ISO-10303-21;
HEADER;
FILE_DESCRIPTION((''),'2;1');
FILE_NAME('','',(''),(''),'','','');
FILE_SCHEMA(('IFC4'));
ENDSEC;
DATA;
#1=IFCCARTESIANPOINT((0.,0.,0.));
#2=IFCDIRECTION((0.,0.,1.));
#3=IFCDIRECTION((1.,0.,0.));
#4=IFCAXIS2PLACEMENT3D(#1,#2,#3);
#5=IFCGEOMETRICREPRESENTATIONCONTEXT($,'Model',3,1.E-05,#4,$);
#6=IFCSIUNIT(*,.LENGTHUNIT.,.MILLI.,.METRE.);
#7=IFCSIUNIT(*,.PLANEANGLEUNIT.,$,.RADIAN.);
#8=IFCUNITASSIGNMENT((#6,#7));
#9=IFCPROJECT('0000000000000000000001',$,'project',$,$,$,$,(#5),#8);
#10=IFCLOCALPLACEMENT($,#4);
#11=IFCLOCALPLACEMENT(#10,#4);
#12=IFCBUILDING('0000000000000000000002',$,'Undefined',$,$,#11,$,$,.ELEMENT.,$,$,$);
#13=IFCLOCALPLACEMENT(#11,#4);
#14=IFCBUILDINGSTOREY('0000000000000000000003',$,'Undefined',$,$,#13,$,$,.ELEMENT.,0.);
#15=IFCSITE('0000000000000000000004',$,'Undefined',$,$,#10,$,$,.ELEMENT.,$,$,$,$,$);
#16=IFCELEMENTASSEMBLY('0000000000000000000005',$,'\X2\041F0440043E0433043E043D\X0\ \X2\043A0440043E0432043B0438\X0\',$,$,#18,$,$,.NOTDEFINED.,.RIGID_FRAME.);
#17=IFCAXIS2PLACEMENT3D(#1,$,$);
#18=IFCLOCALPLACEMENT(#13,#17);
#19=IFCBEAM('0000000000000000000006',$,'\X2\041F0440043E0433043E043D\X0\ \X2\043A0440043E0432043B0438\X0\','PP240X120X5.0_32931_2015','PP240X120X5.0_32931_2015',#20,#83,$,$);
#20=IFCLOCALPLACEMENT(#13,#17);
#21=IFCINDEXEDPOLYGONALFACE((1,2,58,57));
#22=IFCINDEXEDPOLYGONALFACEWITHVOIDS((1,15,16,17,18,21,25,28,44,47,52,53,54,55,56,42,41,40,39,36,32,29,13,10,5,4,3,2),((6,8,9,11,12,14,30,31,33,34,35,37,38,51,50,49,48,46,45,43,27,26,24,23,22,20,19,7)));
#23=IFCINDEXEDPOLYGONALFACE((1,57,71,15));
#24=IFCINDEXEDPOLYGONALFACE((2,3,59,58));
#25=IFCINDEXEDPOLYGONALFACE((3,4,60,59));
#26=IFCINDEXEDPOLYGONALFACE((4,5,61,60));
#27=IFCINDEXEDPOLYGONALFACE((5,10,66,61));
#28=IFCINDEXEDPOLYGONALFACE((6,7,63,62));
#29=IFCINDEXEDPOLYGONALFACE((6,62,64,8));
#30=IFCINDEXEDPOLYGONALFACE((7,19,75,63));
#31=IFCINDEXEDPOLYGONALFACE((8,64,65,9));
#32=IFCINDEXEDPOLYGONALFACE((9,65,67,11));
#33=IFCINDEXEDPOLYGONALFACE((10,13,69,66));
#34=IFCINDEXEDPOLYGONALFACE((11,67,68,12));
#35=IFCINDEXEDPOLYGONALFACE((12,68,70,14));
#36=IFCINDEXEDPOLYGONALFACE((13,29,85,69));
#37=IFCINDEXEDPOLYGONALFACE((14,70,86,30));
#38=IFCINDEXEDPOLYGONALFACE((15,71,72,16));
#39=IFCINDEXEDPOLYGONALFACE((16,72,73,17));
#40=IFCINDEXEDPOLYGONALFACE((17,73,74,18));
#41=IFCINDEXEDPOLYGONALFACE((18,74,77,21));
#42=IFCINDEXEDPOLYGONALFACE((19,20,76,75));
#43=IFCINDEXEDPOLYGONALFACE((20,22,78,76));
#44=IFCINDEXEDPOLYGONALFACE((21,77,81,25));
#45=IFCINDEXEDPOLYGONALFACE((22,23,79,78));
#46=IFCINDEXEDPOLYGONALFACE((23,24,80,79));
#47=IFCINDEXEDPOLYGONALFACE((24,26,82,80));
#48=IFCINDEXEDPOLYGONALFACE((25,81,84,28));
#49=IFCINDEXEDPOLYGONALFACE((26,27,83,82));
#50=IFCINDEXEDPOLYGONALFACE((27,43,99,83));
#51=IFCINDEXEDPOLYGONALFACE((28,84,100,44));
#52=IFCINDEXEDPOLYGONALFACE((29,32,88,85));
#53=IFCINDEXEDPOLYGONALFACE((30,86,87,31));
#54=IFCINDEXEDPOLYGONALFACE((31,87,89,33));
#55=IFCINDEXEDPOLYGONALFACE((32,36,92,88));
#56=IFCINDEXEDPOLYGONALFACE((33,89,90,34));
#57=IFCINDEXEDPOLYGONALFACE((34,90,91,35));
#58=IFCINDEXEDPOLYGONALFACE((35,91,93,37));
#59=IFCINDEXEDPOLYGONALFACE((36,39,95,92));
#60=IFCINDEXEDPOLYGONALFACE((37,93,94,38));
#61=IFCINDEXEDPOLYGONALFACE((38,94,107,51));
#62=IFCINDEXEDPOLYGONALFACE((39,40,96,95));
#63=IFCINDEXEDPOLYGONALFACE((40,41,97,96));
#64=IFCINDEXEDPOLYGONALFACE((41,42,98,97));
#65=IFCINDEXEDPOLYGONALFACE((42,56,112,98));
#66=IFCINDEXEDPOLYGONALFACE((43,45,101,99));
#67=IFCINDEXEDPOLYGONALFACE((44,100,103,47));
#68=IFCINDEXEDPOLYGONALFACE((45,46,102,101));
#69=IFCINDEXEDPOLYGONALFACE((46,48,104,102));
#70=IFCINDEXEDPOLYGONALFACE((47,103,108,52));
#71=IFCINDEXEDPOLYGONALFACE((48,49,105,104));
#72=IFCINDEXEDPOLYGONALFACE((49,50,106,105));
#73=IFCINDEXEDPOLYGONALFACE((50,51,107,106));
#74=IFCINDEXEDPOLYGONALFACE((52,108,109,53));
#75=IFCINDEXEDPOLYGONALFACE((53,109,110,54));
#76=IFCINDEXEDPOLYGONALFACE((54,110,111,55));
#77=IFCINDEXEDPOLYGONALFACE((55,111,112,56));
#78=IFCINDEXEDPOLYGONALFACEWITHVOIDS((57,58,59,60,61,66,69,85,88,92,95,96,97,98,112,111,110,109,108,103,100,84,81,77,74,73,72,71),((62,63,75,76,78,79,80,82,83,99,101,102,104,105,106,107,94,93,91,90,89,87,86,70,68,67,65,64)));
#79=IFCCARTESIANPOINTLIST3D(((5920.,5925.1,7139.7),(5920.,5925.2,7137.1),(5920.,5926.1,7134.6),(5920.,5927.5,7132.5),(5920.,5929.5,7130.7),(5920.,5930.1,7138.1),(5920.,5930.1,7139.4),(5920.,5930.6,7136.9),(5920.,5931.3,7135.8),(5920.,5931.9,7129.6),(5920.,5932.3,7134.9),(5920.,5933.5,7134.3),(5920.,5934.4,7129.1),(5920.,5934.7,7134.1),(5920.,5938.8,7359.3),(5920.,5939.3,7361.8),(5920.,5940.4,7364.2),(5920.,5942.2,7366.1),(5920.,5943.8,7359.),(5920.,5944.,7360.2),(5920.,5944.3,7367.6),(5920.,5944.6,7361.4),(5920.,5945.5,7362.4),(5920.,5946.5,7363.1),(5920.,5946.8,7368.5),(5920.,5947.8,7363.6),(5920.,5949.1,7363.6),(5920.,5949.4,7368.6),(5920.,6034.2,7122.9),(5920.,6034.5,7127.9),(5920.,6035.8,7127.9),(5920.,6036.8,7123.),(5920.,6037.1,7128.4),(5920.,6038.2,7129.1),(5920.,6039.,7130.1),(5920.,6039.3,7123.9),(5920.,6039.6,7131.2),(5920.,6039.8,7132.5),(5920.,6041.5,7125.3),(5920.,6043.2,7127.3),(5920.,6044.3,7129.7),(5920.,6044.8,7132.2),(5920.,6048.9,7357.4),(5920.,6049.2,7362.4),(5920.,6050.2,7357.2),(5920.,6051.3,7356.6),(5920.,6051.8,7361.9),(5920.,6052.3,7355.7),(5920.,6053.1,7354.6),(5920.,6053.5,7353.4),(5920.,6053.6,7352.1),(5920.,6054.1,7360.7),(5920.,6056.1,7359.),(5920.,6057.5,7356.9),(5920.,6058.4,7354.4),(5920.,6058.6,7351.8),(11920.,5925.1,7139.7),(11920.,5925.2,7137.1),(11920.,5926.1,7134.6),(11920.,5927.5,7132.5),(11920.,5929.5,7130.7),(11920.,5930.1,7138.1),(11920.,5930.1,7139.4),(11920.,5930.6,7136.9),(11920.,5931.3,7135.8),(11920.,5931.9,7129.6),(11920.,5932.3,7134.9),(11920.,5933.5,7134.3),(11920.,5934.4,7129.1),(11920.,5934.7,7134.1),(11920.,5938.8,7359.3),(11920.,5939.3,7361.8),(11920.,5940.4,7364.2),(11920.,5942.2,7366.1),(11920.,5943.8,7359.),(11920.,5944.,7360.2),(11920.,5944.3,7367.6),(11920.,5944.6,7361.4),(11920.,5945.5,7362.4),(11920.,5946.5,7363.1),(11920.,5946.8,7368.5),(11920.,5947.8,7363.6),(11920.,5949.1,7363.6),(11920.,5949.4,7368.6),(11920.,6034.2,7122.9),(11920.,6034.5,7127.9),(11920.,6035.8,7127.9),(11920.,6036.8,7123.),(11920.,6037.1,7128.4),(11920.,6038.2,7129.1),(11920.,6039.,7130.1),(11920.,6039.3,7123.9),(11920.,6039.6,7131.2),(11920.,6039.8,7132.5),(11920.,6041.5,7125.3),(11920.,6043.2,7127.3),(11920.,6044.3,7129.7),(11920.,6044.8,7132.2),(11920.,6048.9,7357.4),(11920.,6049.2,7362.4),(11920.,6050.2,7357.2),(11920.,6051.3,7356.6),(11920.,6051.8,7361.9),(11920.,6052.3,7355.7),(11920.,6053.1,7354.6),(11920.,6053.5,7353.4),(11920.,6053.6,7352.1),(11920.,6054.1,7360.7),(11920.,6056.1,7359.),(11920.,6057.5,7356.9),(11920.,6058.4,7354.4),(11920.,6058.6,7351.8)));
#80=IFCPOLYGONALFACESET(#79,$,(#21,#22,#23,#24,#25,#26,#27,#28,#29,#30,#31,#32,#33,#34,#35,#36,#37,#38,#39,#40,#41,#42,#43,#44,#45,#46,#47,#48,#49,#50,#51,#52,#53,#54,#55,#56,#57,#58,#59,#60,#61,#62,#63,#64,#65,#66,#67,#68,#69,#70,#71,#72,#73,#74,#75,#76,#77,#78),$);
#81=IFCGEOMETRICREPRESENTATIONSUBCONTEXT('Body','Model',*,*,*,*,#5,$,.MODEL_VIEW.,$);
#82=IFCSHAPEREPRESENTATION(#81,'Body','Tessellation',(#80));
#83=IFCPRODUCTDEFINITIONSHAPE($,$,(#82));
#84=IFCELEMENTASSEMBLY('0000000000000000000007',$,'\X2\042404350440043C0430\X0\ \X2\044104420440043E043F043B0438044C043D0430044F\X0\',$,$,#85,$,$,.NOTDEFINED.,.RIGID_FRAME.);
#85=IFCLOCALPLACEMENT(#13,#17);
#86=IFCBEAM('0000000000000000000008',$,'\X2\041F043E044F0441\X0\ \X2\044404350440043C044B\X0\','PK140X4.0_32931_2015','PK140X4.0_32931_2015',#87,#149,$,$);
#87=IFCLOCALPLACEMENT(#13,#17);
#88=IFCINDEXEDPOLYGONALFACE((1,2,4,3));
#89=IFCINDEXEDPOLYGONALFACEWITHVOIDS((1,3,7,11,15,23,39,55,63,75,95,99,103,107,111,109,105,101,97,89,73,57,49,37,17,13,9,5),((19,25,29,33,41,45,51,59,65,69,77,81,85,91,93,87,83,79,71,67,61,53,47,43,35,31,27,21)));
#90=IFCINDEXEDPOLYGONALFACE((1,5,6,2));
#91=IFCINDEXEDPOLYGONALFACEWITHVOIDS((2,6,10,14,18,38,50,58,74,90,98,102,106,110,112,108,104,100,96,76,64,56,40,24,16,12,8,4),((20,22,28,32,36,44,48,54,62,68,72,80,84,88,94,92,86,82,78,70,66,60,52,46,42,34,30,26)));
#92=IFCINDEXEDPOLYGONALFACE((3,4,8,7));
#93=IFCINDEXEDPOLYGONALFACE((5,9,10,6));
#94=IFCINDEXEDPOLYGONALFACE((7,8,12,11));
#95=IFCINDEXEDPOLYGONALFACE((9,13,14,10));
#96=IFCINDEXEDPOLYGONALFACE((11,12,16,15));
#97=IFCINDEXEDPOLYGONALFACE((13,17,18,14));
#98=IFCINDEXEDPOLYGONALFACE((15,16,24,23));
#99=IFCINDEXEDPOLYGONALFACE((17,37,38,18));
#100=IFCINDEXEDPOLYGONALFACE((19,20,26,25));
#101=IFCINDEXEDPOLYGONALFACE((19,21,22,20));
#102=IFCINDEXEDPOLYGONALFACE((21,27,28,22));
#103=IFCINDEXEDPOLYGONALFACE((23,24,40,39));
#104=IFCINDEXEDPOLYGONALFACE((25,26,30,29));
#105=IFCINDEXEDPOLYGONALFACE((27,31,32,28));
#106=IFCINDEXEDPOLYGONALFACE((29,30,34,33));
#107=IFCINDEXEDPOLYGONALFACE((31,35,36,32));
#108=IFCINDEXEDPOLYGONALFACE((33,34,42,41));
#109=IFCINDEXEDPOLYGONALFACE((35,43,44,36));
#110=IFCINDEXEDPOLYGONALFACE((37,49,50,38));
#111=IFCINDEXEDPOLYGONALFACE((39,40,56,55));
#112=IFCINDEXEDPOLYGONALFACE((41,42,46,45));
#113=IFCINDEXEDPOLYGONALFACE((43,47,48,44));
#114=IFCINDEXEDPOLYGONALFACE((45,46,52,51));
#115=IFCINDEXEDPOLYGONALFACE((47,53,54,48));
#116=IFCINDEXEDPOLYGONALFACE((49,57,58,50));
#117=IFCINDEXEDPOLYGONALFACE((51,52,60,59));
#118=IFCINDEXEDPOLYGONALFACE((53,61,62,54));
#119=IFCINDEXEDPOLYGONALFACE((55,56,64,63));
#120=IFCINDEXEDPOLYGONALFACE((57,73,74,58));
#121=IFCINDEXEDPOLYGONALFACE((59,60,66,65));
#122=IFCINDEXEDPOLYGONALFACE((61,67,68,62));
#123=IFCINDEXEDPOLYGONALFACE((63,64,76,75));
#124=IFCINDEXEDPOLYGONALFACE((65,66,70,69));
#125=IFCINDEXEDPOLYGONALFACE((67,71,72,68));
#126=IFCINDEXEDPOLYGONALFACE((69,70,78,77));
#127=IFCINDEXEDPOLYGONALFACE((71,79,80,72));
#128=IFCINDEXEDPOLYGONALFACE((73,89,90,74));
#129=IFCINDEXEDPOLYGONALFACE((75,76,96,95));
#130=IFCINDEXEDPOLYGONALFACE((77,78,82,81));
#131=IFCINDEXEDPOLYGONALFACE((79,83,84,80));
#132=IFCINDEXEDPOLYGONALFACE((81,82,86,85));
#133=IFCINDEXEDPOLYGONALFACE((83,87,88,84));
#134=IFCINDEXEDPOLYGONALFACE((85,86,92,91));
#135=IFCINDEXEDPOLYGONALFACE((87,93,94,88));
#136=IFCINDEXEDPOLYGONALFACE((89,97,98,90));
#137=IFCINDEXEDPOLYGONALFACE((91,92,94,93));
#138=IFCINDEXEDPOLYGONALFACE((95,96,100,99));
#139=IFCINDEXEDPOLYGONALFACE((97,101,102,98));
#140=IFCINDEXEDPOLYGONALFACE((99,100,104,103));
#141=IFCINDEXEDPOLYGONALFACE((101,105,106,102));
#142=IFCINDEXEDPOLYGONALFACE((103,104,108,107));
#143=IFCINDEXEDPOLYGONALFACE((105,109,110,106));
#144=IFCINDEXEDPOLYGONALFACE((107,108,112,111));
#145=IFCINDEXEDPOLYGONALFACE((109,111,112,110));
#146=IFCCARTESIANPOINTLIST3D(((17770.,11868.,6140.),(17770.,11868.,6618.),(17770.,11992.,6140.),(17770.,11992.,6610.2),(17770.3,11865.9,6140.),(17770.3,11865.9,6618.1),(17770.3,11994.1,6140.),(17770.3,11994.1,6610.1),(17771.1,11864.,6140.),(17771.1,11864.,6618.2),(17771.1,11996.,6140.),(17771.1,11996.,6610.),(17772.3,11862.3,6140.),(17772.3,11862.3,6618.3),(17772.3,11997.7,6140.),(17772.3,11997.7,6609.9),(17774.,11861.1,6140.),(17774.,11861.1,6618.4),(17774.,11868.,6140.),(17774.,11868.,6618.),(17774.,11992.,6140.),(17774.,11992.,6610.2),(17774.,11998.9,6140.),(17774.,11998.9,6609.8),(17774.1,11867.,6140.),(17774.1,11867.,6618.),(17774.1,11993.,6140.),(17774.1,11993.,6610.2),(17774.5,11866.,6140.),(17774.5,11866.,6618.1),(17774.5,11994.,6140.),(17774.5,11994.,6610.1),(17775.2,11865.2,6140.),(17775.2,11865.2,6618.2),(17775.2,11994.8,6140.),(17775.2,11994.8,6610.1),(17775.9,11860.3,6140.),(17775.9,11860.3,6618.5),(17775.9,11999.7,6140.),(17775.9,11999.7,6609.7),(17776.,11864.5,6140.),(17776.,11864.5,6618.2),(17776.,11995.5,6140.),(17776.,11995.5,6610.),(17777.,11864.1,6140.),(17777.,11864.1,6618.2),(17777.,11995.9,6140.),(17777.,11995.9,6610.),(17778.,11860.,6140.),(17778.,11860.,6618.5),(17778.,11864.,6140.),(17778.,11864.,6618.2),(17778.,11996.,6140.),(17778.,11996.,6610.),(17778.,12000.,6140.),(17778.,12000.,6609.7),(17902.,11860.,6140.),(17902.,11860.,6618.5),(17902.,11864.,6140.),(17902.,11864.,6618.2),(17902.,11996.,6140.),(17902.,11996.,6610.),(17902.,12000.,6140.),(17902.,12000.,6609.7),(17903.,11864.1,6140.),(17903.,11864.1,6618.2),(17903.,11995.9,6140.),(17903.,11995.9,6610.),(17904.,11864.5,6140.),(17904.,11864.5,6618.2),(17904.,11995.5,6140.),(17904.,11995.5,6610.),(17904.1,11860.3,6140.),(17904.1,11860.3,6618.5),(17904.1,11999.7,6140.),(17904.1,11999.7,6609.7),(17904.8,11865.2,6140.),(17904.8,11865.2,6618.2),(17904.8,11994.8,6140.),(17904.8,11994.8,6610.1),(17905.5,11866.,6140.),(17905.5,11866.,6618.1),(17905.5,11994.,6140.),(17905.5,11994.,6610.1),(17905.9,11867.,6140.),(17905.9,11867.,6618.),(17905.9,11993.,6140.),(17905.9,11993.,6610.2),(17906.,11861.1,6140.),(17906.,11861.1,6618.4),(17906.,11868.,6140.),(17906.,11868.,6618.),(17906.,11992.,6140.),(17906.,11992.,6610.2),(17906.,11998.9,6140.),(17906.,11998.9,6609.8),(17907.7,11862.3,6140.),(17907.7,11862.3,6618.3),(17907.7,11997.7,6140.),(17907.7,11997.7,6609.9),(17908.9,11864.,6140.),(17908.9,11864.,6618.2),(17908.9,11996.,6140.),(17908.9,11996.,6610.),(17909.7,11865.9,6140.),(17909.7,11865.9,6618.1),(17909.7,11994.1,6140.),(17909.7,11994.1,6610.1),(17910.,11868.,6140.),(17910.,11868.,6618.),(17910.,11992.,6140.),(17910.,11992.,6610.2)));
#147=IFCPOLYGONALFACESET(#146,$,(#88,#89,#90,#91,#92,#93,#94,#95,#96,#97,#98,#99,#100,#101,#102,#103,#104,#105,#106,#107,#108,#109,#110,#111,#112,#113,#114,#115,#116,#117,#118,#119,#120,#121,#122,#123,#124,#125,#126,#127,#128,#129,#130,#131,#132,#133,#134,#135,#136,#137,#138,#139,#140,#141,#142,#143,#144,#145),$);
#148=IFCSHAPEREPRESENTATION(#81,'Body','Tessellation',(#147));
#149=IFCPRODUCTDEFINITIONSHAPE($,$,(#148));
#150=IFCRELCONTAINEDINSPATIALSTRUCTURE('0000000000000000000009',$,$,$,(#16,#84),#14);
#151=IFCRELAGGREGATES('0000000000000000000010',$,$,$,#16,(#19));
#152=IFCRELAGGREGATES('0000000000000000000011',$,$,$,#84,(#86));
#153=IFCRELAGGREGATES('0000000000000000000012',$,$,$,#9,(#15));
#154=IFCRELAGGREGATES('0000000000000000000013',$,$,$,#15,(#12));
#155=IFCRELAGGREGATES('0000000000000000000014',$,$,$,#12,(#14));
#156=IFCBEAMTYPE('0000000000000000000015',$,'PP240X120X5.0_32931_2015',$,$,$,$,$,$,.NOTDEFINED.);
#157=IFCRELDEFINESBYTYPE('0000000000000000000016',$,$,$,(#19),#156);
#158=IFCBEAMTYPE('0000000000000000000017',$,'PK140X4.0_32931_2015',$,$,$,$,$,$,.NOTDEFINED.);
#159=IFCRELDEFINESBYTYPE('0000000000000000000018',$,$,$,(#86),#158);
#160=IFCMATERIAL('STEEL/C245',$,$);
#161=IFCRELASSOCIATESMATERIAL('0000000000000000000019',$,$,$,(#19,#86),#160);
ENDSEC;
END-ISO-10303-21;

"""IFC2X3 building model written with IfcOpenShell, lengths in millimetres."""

from ifc_helpers import new_model, si_unit, frame, origin_with_axes, origin_2d_with_axis, place, context, subcontext, project, spatial, hollow_rectangle, extrude, clip, halfspace, material, type_object, element, aggregate, save


model = new_model("IFC2X3")

# Units and contexts
model_context = context("Model", 3, precision=1e-05, world=origin_with_axes())
body_context = subcontext(model_context, "Body", "Model", "MODEL_VIEW")
ifc_project = project(units=[si_unit("LENGTHUNIT", "METRE", prefix="MILLI"), si_unit("PLANEANGLEUNIT", "RADIAN")], contexts=[model_context])

# Site, building, storey
site_placement = place(None, origin_with_axes())
site = spatial("IfcSite", under=ifc_project, at=site_placement, Name="Undefined", CompositionType="ELEMENT")
building_placement = place(site_placement, origin_with_axes())
building = spatial("IfcBuilding", under=site, at=building_placement, Name="Undefined", CompositionType="ELEMENT")
storey_placement = place(building_placement, origin_with_axes())
storey = spatial("IfcBuildingStorey", under=building, at=storey_placement, Name="Undefined", CompositionType="ELEMENT", Elevation=0.0)

# Shared definitions
ifc_material = material(Name="STEEL/C245")

# Element assembly, beam
beam_type_1 = type_object("IfcBeamType", Name="PP240X120X5.0_32931_2015", PredefinedType="NOTDEFINED")
assembly_1_placement = place(storey_placement, origin_with_axes())
assembly_1 = element("IfcElementAssembly", 1, at=assembly_1_placement, inside=storey, Name="Прогон кровли", AssemblyPlace="NOTDEFINED", PredefinedType="RIGID_FRAME")
beam_1_placement = place(assembly_1_placement, frame((11920.0, 5991.8, 7245.7), z_axis=(0.0, 0.062378, 0.998053), x_axis=(-1.0, 0.0, 0.0)))
beam_1 = element("IfcBeam", 2, at=beam_1_placement, type_object=beam_type_1, material=ifc_material, Name="Прогон кровли", Description="PP240X120X5.0_32931_2015", ObjectType="PP240X120X5.0_32931_2015", context=body_context, shape_type="SweptSolid", body=[
    extrude(hollow_rectangle(XDim=120.0, YDim=240.0, WallThickness=5.0, InnerFilletRadius=5.0, OuterFilletRadius=10.0, at=origin_2d_with_axis()), frame((6000.0, 0.0, 0.0), z_axis=(-1.0, 0.0, 0.0), x_axis=(0.0, -1.0, 0.0)), (0.0, 0.0, 1.0), 6000.0),
])
aggregate(assembly_1, [beam_1])

# Element assembly
assembly_2_placement = place(storey_placement, origin_with_axes())
assembly_2 = element("IfcElementAssembly", 3, at=assembly_2_placement, inside=storey, Name="Ферма строплиьная", AssemblyPlace="NOTDEFINED", PredefinedType="RIGID_FRAME")

# Beam
beam_type_2 = type_object("IfcBeamType", Name="PK140X4.0_32931_2015", PredefinedType="NOTDEFINED")
beam_2_placement = place(assembly_2_placement, frame((17840.0, 11930.0, 6609.7), z_axis=(1.0, 0.0, 0.0), x_axis=(0.0, 0.0, -1.0)))
beam_2 = element("IfcBeam", 4, at=beam_2_placement, type_object=beam_type_2, material=ifc_material, Name="Пояс фермы", Description="PK140X4.0_32931_2015", ObjectType="PK140X4.0_32931_2015", context=body_context, shape_type="Clipping", body=[
    clip(extrude(hollow_rectangle(XDim=140.0, YDim=140.0, WallThickness=4.0, InnerFilletRadius=4.0, OuterFilletRadius=8.0, at=origin_2d_with_axis()), frame((469.7, 0.0, 0.0), z_axis=(-1.0, 0.0, 0.0), x_axis=(0.0, -1.0, 0.0)), (0.0, 0.0, 1.0), 478.5), halfspace(frame((-14.9, -167.6, 0.0), z_axis=(-0.998053, 0.062378, 0.0), x_axis=(0.0, 0.0, 1.0)), False)),
])
aggregate(assembly_2, [beam_2])

save(model, "model.ifc")
